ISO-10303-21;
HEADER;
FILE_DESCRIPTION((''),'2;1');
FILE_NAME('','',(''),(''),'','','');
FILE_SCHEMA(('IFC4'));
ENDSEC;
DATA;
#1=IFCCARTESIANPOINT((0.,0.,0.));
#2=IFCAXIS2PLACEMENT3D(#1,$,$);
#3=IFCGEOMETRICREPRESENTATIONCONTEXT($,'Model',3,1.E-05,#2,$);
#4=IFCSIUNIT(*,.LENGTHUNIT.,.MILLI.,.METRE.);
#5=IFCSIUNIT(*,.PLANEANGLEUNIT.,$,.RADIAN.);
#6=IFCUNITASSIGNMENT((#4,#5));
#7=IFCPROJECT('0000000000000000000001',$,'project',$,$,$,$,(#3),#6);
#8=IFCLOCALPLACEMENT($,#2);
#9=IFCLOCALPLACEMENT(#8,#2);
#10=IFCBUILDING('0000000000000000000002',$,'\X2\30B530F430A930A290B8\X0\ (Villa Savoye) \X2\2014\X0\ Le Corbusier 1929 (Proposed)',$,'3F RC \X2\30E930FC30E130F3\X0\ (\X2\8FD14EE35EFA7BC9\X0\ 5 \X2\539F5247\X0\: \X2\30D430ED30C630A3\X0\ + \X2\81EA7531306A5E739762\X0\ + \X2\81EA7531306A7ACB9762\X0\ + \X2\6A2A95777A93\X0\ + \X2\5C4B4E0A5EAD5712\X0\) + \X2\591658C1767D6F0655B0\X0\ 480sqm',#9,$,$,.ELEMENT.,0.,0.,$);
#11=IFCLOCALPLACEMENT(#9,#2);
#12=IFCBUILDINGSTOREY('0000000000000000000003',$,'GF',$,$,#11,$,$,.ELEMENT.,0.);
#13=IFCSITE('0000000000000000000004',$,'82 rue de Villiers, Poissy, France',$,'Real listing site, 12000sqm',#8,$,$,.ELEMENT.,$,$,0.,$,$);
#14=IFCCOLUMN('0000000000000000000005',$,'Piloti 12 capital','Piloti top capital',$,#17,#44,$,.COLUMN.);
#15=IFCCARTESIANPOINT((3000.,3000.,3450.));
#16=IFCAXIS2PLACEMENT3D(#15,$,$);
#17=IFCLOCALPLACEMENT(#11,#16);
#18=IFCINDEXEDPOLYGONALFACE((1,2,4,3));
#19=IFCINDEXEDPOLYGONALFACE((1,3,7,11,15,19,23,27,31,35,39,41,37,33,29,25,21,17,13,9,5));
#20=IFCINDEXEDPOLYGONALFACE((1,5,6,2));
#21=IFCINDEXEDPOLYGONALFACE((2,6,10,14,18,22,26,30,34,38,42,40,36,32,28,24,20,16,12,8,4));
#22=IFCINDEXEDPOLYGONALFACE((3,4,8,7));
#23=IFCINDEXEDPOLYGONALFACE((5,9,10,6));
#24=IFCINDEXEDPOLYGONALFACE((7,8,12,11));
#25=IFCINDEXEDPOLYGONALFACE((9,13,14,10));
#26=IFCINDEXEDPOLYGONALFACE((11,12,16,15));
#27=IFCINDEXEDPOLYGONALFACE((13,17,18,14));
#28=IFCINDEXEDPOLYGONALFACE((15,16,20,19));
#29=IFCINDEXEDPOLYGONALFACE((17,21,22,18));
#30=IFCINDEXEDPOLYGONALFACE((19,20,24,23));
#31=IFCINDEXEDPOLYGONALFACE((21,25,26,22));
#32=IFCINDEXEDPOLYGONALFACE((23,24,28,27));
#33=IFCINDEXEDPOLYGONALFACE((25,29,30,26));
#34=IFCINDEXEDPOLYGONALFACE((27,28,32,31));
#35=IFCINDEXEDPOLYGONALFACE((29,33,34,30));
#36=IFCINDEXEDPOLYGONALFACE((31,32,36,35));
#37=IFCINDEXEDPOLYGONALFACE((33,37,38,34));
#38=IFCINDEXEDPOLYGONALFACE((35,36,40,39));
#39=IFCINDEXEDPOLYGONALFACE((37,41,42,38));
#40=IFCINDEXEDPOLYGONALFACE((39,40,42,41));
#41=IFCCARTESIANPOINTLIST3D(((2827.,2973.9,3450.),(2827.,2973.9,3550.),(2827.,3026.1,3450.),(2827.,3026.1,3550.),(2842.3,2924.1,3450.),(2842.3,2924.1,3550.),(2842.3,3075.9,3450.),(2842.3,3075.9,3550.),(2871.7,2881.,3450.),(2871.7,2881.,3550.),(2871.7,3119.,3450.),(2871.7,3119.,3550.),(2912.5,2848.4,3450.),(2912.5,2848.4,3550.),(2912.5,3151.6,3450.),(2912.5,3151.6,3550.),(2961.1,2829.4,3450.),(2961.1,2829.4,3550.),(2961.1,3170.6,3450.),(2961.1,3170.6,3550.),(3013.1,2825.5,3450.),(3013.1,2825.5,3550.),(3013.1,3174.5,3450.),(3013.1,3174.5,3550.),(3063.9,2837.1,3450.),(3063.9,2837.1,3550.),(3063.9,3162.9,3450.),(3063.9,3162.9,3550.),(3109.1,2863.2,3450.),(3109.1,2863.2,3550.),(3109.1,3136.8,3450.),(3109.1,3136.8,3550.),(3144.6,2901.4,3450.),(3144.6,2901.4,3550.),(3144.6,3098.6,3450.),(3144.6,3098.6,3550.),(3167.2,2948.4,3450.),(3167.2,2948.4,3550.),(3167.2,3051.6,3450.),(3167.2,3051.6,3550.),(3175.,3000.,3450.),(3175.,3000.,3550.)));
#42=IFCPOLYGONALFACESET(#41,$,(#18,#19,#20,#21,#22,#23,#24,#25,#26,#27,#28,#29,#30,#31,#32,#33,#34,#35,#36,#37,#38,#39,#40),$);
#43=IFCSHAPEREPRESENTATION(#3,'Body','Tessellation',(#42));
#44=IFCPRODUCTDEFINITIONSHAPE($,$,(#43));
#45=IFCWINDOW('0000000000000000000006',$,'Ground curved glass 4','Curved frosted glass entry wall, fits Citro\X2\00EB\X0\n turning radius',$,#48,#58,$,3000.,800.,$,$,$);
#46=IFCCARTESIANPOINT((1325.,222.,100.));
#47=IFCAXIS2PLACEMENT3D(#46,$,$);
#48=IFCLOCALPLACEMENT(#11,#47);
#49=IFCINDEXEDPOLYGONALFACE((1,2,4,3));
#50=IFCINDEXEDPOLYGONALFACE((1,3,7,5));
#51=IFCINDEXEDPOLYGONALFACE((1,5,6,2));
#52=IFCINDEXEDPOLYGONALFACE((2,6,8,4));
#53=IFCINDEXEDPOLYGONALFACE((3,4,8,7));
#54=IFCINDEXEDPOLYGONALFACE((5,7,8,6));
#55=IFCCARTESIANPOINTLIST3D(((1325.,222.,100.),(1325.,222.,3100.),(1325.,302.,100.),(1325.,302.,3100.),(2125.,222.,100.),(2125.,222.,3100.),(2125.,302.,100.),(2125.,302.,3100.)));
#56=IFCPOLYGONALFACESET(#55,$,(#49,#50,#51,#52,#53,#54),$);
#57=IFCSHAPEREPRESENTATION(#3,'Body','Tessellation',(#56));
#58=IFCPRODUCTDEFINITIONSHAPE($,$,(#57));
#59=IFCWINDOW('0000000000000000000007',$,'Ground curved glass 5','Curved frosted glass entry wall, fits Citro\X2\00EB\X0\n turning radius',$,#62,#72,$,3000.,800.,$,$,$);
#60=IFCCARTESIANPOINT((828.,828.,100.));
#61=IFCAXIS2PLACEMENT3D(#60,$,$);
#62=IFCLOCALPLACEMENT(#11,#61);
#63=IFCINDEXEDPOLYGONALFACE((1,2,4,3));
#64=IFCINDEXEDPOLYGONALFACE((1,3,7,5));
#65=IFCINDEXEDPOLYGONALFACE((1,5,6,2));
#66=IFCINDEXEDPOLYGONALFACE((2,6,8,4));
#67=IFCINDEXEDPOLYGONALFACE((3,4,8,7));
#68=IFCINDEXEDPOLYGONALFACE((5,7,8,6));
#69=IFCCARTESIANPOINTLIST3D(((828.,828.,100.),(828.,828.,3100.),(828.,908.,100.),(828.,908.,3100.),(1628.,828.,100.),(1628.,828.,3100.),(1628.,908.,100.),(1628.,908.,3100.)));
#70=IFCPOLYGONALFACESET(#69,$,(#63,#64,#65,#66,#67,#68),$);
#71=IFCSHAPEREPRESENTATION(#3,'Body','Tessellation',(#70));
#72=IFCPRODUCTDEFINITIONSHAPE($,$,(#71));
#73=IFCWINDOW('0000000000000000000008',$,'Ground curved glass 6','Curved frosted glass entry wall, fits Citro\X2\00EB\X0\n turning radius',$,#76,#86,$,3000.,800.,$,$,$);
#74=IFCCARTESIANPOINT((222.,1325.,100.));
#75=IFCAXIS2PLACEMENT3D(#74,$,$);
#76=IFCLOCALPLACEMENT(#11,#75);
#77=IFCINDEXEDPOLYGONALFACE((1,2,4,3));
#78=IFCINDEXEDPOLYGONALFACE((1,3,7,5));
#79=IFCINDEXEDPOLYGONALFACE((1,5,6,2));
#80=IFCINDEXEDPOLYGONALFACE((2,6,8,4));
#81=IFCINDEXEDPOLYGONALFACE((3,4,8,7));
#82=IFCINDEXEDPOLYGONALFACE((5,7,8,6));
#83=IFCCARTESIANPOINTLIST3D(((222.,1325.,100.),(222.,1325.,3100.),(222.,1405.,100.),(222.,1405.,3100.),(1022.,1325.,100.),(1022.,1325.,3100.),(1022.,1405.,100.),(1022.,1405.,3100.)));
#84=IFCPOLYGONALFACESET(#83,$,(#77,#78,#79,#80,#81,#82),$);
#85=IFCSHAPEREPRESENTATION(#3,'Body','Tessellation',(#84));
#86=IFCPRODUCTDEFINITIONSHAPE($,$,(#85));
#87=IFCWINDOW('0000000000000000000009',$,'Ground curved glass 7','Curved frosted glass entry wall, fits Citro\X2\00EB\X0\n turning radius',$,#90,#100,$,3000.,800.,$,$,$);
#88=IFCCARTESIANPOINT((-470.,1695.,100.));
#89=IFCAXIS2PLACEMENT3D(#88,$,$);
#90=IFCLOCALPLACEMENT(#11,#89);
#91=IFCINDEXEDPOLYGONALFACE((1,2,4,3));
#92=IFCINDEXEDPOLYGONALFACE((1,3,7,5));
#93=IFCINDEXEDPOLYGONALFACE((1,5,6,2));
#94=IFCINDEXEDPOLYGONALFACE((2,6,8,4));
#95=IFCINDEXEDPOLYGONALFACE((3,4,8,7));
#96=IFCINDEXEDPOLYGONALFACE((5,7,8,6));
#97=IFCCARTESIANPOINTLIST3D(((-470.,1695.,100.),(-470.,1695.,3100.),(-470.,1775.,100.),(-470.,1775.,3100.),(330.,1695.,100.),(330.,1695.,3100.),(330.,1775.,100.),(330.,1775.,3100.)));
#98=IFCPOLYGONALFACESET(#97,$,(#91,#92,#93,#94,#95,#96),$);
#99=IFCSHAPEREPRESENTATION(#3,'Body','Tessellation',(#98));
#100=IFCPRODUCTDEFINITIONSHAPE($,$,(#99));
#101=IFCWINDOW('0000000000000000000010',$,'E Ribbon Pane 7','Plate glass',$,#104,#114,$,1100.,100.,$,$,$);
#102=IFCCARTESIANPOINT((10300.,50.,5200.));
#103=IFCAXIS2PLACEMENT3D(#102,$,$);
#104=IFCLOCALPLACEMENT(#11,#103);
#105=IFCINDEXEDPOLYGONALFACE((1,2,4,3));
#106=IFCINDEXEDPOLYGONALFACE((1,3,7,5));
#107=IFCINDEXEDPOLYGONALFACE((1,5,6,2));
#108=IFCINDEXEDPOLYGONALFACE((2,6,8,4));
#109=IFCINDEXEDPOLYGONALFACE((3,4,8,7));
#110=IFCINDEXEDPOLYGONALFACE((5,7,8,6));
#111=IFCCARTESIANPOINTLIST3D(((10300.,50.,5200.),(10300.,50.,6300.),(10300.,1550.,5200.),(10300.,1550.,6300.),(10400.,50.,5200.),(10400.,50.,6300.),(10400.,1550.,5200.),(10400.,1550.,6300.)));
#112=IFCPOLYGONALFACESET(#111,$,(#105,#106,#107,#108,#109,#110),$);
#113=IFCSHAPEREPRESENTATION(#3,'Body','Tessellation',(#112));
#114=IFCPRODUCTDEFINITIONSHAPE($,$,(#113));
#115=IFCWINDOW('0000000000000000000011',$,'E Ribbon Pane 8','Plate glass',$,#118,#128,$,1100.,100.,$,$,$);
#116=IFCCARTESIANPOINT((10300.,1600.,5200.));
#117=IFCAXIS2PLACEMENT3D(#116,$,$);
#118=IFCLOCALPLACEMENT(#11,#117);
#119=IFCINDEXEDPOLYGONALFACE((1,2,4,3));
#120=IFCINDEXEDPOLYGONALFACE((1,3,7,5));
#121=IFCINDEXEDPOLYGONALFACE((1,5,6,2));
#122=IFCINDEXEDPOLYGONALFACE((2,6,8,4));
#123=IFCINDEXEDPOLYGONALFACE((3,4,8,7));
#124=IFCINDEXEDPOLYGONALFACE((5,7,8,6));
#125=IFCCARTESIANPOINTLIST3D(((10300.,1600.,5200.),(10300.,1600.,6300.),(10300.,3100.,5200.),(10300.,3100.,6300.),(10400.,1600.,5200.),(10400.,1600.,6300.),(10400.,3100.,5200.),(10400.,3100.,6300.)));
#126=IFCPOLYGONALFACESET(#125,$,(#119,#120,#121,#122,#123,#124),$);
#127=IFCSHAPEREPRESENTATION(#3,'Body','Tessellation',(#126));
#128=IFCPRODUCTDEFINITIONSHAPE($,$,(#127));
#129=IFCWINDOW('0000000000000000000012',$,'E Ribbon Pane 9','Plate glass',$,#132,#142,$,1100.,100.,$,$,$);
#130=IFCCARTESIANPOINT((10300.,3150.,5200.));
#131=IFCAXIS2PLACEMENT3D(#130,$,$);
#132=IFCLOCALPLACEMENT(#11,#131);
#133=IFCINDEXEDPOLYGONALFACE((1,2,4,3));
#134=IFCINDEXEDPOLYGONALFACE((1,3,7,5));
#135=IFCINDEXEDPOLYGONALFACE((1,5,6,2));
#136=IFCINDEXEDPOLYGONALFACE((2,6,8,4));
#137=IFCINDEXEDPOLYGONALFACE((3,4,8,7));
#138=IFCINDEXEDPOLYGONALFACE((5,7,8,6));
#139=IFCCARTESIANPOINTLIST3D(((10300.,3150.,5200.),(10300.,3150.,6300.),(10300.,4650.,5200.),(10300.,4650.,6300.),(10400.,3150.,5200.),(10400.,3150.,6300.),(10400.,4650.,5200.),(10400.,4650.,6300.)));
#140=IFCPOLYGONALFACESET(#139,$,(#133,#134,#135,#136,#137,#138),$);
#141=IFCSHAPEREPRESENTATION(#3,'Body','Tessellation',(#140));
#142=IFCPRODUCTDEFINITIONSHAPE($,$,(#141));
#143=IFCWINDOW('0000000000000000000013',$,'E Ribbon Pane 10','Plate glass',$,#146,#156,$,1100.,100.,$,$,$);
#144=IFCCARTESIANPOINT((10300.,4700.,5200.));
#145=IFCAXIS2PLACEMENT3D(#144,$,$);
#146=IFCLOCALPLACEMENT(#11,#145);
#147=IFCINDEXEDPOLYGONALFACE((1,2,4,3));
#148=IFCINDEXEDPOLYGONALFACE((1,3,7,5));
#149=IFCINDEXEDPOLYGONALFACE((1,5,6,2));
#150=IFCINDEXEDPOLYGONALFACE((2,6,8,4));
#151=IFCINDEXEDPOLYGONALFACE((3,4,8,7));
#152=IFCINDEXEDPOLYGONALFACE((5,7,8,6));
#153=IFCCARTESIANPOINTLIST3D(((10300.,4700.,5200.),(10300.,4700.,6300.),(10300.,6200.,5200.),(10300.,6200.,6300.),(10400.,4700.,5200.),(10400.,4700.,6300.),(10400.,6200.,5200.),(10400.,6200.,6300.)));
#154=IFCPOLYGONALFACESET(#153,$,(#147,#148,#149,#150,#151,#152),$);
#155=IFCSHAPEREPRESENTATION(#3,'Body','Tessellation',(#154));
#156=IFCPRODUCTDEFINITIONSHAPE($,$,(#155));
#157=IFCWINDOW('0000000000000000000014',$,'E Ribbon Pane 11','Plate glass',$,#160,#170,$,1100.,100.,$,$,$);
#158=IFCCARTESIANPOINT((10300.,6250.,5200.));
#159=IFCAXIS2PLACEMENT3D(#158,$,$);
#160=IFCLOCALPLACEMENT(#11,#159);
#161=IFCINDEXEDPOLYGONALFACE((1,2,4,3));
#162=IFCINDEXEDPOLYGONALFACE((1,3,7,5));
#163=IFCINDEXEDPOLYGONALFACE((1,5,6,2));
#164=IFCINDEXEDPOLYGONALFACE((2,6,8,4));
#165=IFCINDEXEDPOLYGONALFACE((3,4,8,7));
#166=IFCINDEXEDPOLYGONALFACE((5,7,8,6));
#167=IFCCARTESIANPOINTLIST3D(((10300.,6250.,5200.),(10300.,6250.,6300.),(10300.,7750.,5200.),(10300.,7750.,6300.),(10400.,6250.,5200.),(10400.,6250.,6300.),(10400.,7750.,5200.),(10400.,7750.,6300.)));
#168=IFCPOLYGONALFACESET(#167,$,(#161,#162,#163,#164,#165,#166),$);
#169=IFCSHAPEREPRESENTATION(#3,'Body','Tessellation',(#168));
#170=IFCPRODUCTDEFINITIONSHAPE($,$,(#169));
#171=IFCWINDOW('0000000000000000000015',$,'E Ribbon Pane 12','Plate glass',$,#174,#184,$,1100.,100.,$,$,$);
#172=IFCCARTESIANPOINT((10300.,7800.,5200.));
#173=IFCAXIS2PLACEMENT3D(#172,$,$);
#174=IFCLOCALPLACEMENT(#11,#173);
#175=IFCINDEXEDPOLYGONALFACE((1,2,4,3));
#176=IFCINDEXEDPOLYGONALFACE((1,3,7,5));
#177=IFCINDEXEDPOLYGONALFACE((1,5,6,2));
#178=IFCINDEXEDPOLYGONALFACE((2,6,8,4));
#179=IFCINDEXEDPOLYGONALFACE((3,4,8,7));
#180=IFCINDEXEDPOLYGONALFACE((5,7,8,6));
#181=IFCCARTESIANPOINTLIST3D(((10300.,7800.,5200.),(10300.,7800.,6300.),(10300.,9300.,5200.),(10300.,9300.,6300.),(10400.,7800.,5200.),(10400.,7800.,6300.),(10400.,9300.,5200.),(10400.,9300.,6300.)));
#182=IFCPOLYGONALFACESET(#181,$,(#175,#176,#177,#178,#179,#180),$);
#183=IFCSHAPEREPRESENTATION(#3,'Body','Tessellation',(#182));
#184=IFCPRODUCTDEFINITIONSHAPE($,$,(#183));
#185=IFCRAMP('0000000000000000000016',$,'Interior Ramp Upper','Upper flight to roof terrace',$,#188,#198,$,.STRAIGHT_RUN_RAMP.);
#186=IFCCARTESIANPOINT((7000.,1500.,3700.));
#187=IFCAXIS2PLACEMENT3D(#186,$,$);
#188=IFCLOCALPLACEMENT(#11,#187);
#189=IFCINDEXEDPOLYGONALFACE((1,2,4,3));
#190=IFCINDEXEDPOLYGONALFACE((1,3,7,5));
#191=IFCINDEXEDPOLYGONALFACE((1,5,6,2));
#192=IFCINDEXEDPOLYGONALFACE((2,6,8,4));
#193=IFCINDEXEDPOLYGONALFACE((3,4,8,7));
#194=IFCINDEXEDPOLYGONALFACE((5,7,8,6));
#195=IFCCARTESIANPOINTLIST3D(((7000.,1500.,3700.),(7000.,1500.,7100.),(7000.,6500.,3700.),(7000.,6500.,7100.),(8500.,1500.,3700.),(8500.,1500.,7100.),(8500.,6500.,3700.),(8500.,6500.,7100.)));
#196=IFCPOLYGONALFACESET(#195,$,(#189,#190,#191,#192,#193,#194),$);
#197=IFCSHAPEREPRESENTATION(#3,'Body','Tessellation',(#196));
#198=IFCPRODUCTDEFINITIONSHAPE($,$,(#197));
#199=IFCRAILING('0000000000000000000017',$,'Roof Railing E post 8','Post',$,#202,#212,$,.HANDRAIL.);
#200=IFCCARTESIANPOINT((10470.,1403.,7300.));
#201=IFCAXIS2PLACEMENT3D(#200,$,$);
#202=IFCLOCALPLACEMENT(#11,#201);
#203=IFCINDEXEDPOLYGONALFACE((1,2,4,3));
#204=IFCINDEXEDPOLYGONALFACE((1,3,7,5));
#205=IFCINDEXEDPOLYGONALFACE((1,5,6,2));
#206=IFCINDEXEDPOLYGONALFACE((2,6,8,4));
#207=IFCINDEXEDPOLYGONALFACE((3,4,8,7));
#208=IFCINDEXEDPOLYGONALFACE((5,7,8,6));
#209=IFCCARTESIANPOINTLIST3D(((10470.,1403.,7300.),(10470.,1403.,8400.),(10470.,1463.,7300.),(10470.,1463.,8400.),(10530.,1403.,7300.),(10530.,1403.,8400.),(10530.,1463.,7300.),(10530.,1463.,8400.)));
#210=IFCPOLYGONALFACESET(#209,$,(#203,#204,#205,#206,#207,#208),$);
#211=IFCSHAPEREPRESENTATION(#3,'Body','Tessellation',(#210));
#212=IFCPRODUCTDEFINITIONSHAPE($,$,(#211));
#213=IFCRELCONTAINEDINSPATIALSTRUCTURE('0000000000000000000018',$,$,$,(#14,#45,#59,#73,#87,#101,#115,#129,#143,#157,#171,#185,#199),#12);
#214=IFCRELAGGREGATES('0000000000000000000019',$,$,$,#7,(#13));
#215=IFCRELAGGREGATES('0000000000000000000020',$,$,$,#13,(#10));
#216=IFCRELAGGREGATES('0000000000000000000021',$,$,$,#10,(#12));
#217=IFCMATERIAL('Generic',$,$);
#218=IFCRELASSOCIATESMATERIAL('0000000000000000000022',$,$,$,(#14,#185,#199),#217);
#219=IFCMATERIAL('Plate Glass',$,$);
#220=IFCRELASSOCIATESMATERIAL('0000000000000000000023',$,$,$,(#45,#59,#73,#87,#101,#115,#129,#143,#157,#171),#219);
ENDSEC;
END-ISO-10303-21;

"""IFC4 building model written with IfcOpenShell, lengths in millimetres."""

from ifc_helpers import new_model, si_unit, frame, frame_2d, origin, origin_2d, place, context, project, spatial, rectangle, circle, extrude, material, element, save


model = new_model("IFC4")

# Units and contexts
model_context = context("Model", 3, precision=1e-05, world=origin())
ifc_project = project(units=[si_unit("LENGTHUNIT", "METRE", prefix="MILLI"), si_unit("PLANEANGLEUNIT", "RADIAN")], contexts=[model_context])

# Site, building, storey
site_placement = place(None, origin())
site = spatial("IfcSite", under=ifc_project, at=site_placement, Name="82 rue de Villiers, Poissy, France", ObjectType="Real listing site, 12000sqm", CompositionType="ELEMENT", RefElevation=0.0)
building_placement = place(site_placement, origin())
building = spatial("IfcBuilding", under=site, at=building_placement, Name="サヴォア邸 (Villa Savoye) — Le Corbusier 1929 (Proposed)", ObjectType="3F RC ラーメン (近代建築 5 原則: ピロティ + 自由な平面 + 自由な立面 + 横長窓 + 屋上庭園) + 外壁白漆喰 480sqm", CompositionType="ELEMENT", ElevationOfRefHeight=0.0, ElevationOfTerrain=0.0)
storey_placement = place(building_placement, origin())
storey = spatial("IfcBuildingStorey", under=building, at=storey_placement, Name="GF", CompositionType="ELEMENT", Elevation=0.0)

# Column
ifc_material_1 = material(Name="Generic")
column_1_placement = place(storey_placement, frame((3000.0, 3000.0, 3450.0)))
element("IfcColumn", 1, at=column_1_placement, inside=storey, material=ifc_material_1, Name="Piloti 12 capital", Description="Piloti top capital", PredefinedType="COLUMN", context=model_context, shape_type="SweptSolid", body=[
    extrude(circle(Radius=175.0, at=origin_2d()), frame((3000.0, 3000.0, 3450.0)), (0.0, 0.0, 1.0), 100.0),
])

# Windows
ifc_material_2 = material(Name="Plate Glass")
window_1_placement = place(storey_placement, frame((1325.0, 222.0, 100.0)))
element("IfcWindow", 2, at=window_1_placement, inside=storey, material=ifc_material_2, Name="Ground curved glass 4", Description="Curved frosted glass entry wall, fits Citroën turning radius", OverallHeight=3000.0, OverallWidth=800.0, context=model_context, shape_type="SweptSolid", body=[
    extrude(rectangle(XDim=800.0, YDim=80.0, at=frame_2d((400.0, 40.0))), frame((1325.0, 222.0, 100.0)), (0.0, 0.0, 1.0), 3000.0),
])
window_2_placement = place(storey_placement, frame((828.0, 828.0, 100.0)))
element("IfcWindow", 3, at=window_2_placement, inside=storey, material=ifc_material_2, Name="Ground curved glass 5", Description="Curved frosted glass entry wall, fits Citroën turning radius", OverallHeight=3000.0, OverallWidth=800.0, context=model_context, shape_type="SweptSolid", body=[
    extrude(rectangle(XDim=800.0, YDim=80.0, at=frame_2d((400.0, 40.0))), frame((828.0, 828.0, 100.0)), (0.0, 0.0, 1.0), 3000.0),
])
window_3_placement = place(storey_placement, frame((222.0, 1325.0, 100.0)))
element("IfcWindow", 4, at=window_3_placement, inside=storey, material=ifc_material_2, Name="Ground curved glass 6", Description="Curved frosted glass entry wall, fits Citroën turning radius", OverallHeight=3000.0, OverallWidth=800.0, context=model_context, shape_type="SweptSolid", body=[
    extrude(rectangle(XDim=800.0, YDim=80.0, at=frame_2d((400.0, 40.0))), frame((222.0, 1325.0, 100.0)), (0.0, 0.0, 1.0), 3000.0),
])
window_4_placement = place(storey_placement, frame((-470.0, 1695.0, 100.0)))
element("IfcWindow", 5, at=window_4_placement, inside=storey, material=ifc_material_2, Name="Ground curved glass 7", Description="Curved frosted glass entry wall, fits Citroën turning radius", OverallHeight=3000.0, OverallWidth=800.0, context=model_context, shape_type="SweptSolid", body=[
    extrude(rectangle(XDim=800.0, YDim=80.0, at=frame_2d((400.0, 40.0))), frame((-470.0, 1695.0, 100.0)), (0.0, 0.0, 1.0), 3000.0),
])
window_5_placement = place(storey_placement, frame((10300.0, 50.0, 5200.0)))
element("IfcWindow", 6, at=window_5_placement, inside=storey, material=ifc_material_2, Name="E Ribbon Pane 7", Description="Plate glass", OverallHeight=1100.0, OverallWidth=100.0, context=model_context, shape_type="SweptSolid", body=[
    extrude(rectangle(XDim=100.0, YDim=1500.0, at=frame_2d((50.0, 750.0))), frame((10300.0, 50.0, 5200.0)), (0.0, 0.0, 1.0), 1100.0),
])
window_6_placement = place(storey_placement, frame((10300.0, 1600.0, 5200.0)))
element("IfcWindow", 7, at=window_6_placement, inside=storey, material=ifc_material_2, Name="E Ribbon Pane 8", Description="Plate glass", OverallHeight=1100.0, OverallWidth=100.0, context=model_context, shape_type="SweptSolid", body=[
    extrude(rectangle(XDim=100.0, YDim=1500.0, at=frame_2d((50.0, 750.0))), frame((10300.0, 1600.0, 5200.0)), (0.0, 0.0, 1.0), 1100.0),
])
window_7_placement = place(storey_placement, frame((10300.0, 3150.0, 5200.0)))
element("IfcWindow", 8, at=window_7_placement, inside=storey, material=ifc_material_2, Name="E Ribbon Pane 9", Description="Plate glass", OverallHeight=1100.0, OverallWidth=100.0, context=model_context, shape_type="SweptSolid", body=[
    extrude(rectangle(XDim=100.0, YDim=1500.0, at=frame_2d((50.0, 750.0))), frame((10300.0, 3150.0, 5200.0)), (0.0, 0.0, 1.0), 1100.0),
])
window_8_placement = place(storey_placement, frame((10300.0, 4700.0, 5200.0)))
element("IfcWindow", 9, at=window_8_placement, inside=storey, material=ifc_material_2, Name="E Ribbon Pane 10", Description="Plate glass", OverallHeight=1100.0, OverallWidth=100.0, context=model_context, shape_type="SweptSolid", body=[
    extrude(rectangle(XDim=100.0, YDim=1500.0, at=frame_2d((50.0, 750.0))), frame((10300.0, 4700.0, 5200.0)), (0.0, 0.0, 1.0), 1100.0),
])
window_9_placement = place(storey_placement, frame((10300.0, 6250.0, 5200.0)))
element("IfcWindow", 10, at=window_9_placement, inside=storey, material=ifc_material_2, Name="E Ribbon Pane 11", Description="Plate glass", OverallHeight=1100.0, OverallWidth=100.0, context=model_context, shape_type="SweptSolid", body=[
    extrude(rectangle(XDim=100.0, YDim=1500.0, at=frame_2d((50.0, 750.0))), frame((10300.0, 6250.0, 5200.0)), (0.0, 0.0, 1.0), 1100.0),
])
window_10_placement = place(storey_placement, frame((10300.0, 7800.0, 5200.0)))
element("IfcWindow", 11, at=window_10_placement, inside=storey, material=ifc_material_2, Name="E Ribbon Pane 12", Description="Plate glass", OverallHeight=1100.0, OverallWidth=100.0, context=model_context, shape_type="SweptSolid", body=[
    extrude(rectangle(XDim=100.0, YDim=1500.0, at=frame_2d((50.0, 750.0))), frame((10300.0, 7800.0, 5200.0)), (0.0, 0.0, 1.0), 1100.0),
])

# Ramp
ramp_placement = place(storey_placement, frame((7000.0, 1500.0, 3700.0)))
element("IfcRamp", 12, at=ramp_placement, inside=storey, material=ifc_material_1, Name="Interior Ramp Upper", Description="Upper flight to roof terrace", PredefinedType="STRAIGHT_RUN_RAMP", context=model_context, shape_type="SweptSolid", body=[
    extrude(rectangle(XDim=1500.0, YDim=5000.0, at=frame_2d((750.0, 2500.0))), frame((7000.0, 1500.0, 3700.0)), (0.0, 0.0, 1.0), 3400.0),
])

# Railing
railing_1_placement = place(storey_placement, frame((10470.0, 1403.0, 7300.0)))
element("IfcRailing", 13, at=railing_1_placement, inside=storey, material=ifc_material_1, Name="Roof Railing E post 8", Description="Post", PredefinedType="HANDRAIL", context=model_context, shape_type="SweptSolid", body=[
    extrude(rectangle(XDim=60.0, YDim=60.0, at=frame_2d((30.0, 30.0))), frame((10470.0, 1403.0, 7300.0)), (0.0, 0.0, 1.0), 1100.0),
])

save(model, "model.ifc")
